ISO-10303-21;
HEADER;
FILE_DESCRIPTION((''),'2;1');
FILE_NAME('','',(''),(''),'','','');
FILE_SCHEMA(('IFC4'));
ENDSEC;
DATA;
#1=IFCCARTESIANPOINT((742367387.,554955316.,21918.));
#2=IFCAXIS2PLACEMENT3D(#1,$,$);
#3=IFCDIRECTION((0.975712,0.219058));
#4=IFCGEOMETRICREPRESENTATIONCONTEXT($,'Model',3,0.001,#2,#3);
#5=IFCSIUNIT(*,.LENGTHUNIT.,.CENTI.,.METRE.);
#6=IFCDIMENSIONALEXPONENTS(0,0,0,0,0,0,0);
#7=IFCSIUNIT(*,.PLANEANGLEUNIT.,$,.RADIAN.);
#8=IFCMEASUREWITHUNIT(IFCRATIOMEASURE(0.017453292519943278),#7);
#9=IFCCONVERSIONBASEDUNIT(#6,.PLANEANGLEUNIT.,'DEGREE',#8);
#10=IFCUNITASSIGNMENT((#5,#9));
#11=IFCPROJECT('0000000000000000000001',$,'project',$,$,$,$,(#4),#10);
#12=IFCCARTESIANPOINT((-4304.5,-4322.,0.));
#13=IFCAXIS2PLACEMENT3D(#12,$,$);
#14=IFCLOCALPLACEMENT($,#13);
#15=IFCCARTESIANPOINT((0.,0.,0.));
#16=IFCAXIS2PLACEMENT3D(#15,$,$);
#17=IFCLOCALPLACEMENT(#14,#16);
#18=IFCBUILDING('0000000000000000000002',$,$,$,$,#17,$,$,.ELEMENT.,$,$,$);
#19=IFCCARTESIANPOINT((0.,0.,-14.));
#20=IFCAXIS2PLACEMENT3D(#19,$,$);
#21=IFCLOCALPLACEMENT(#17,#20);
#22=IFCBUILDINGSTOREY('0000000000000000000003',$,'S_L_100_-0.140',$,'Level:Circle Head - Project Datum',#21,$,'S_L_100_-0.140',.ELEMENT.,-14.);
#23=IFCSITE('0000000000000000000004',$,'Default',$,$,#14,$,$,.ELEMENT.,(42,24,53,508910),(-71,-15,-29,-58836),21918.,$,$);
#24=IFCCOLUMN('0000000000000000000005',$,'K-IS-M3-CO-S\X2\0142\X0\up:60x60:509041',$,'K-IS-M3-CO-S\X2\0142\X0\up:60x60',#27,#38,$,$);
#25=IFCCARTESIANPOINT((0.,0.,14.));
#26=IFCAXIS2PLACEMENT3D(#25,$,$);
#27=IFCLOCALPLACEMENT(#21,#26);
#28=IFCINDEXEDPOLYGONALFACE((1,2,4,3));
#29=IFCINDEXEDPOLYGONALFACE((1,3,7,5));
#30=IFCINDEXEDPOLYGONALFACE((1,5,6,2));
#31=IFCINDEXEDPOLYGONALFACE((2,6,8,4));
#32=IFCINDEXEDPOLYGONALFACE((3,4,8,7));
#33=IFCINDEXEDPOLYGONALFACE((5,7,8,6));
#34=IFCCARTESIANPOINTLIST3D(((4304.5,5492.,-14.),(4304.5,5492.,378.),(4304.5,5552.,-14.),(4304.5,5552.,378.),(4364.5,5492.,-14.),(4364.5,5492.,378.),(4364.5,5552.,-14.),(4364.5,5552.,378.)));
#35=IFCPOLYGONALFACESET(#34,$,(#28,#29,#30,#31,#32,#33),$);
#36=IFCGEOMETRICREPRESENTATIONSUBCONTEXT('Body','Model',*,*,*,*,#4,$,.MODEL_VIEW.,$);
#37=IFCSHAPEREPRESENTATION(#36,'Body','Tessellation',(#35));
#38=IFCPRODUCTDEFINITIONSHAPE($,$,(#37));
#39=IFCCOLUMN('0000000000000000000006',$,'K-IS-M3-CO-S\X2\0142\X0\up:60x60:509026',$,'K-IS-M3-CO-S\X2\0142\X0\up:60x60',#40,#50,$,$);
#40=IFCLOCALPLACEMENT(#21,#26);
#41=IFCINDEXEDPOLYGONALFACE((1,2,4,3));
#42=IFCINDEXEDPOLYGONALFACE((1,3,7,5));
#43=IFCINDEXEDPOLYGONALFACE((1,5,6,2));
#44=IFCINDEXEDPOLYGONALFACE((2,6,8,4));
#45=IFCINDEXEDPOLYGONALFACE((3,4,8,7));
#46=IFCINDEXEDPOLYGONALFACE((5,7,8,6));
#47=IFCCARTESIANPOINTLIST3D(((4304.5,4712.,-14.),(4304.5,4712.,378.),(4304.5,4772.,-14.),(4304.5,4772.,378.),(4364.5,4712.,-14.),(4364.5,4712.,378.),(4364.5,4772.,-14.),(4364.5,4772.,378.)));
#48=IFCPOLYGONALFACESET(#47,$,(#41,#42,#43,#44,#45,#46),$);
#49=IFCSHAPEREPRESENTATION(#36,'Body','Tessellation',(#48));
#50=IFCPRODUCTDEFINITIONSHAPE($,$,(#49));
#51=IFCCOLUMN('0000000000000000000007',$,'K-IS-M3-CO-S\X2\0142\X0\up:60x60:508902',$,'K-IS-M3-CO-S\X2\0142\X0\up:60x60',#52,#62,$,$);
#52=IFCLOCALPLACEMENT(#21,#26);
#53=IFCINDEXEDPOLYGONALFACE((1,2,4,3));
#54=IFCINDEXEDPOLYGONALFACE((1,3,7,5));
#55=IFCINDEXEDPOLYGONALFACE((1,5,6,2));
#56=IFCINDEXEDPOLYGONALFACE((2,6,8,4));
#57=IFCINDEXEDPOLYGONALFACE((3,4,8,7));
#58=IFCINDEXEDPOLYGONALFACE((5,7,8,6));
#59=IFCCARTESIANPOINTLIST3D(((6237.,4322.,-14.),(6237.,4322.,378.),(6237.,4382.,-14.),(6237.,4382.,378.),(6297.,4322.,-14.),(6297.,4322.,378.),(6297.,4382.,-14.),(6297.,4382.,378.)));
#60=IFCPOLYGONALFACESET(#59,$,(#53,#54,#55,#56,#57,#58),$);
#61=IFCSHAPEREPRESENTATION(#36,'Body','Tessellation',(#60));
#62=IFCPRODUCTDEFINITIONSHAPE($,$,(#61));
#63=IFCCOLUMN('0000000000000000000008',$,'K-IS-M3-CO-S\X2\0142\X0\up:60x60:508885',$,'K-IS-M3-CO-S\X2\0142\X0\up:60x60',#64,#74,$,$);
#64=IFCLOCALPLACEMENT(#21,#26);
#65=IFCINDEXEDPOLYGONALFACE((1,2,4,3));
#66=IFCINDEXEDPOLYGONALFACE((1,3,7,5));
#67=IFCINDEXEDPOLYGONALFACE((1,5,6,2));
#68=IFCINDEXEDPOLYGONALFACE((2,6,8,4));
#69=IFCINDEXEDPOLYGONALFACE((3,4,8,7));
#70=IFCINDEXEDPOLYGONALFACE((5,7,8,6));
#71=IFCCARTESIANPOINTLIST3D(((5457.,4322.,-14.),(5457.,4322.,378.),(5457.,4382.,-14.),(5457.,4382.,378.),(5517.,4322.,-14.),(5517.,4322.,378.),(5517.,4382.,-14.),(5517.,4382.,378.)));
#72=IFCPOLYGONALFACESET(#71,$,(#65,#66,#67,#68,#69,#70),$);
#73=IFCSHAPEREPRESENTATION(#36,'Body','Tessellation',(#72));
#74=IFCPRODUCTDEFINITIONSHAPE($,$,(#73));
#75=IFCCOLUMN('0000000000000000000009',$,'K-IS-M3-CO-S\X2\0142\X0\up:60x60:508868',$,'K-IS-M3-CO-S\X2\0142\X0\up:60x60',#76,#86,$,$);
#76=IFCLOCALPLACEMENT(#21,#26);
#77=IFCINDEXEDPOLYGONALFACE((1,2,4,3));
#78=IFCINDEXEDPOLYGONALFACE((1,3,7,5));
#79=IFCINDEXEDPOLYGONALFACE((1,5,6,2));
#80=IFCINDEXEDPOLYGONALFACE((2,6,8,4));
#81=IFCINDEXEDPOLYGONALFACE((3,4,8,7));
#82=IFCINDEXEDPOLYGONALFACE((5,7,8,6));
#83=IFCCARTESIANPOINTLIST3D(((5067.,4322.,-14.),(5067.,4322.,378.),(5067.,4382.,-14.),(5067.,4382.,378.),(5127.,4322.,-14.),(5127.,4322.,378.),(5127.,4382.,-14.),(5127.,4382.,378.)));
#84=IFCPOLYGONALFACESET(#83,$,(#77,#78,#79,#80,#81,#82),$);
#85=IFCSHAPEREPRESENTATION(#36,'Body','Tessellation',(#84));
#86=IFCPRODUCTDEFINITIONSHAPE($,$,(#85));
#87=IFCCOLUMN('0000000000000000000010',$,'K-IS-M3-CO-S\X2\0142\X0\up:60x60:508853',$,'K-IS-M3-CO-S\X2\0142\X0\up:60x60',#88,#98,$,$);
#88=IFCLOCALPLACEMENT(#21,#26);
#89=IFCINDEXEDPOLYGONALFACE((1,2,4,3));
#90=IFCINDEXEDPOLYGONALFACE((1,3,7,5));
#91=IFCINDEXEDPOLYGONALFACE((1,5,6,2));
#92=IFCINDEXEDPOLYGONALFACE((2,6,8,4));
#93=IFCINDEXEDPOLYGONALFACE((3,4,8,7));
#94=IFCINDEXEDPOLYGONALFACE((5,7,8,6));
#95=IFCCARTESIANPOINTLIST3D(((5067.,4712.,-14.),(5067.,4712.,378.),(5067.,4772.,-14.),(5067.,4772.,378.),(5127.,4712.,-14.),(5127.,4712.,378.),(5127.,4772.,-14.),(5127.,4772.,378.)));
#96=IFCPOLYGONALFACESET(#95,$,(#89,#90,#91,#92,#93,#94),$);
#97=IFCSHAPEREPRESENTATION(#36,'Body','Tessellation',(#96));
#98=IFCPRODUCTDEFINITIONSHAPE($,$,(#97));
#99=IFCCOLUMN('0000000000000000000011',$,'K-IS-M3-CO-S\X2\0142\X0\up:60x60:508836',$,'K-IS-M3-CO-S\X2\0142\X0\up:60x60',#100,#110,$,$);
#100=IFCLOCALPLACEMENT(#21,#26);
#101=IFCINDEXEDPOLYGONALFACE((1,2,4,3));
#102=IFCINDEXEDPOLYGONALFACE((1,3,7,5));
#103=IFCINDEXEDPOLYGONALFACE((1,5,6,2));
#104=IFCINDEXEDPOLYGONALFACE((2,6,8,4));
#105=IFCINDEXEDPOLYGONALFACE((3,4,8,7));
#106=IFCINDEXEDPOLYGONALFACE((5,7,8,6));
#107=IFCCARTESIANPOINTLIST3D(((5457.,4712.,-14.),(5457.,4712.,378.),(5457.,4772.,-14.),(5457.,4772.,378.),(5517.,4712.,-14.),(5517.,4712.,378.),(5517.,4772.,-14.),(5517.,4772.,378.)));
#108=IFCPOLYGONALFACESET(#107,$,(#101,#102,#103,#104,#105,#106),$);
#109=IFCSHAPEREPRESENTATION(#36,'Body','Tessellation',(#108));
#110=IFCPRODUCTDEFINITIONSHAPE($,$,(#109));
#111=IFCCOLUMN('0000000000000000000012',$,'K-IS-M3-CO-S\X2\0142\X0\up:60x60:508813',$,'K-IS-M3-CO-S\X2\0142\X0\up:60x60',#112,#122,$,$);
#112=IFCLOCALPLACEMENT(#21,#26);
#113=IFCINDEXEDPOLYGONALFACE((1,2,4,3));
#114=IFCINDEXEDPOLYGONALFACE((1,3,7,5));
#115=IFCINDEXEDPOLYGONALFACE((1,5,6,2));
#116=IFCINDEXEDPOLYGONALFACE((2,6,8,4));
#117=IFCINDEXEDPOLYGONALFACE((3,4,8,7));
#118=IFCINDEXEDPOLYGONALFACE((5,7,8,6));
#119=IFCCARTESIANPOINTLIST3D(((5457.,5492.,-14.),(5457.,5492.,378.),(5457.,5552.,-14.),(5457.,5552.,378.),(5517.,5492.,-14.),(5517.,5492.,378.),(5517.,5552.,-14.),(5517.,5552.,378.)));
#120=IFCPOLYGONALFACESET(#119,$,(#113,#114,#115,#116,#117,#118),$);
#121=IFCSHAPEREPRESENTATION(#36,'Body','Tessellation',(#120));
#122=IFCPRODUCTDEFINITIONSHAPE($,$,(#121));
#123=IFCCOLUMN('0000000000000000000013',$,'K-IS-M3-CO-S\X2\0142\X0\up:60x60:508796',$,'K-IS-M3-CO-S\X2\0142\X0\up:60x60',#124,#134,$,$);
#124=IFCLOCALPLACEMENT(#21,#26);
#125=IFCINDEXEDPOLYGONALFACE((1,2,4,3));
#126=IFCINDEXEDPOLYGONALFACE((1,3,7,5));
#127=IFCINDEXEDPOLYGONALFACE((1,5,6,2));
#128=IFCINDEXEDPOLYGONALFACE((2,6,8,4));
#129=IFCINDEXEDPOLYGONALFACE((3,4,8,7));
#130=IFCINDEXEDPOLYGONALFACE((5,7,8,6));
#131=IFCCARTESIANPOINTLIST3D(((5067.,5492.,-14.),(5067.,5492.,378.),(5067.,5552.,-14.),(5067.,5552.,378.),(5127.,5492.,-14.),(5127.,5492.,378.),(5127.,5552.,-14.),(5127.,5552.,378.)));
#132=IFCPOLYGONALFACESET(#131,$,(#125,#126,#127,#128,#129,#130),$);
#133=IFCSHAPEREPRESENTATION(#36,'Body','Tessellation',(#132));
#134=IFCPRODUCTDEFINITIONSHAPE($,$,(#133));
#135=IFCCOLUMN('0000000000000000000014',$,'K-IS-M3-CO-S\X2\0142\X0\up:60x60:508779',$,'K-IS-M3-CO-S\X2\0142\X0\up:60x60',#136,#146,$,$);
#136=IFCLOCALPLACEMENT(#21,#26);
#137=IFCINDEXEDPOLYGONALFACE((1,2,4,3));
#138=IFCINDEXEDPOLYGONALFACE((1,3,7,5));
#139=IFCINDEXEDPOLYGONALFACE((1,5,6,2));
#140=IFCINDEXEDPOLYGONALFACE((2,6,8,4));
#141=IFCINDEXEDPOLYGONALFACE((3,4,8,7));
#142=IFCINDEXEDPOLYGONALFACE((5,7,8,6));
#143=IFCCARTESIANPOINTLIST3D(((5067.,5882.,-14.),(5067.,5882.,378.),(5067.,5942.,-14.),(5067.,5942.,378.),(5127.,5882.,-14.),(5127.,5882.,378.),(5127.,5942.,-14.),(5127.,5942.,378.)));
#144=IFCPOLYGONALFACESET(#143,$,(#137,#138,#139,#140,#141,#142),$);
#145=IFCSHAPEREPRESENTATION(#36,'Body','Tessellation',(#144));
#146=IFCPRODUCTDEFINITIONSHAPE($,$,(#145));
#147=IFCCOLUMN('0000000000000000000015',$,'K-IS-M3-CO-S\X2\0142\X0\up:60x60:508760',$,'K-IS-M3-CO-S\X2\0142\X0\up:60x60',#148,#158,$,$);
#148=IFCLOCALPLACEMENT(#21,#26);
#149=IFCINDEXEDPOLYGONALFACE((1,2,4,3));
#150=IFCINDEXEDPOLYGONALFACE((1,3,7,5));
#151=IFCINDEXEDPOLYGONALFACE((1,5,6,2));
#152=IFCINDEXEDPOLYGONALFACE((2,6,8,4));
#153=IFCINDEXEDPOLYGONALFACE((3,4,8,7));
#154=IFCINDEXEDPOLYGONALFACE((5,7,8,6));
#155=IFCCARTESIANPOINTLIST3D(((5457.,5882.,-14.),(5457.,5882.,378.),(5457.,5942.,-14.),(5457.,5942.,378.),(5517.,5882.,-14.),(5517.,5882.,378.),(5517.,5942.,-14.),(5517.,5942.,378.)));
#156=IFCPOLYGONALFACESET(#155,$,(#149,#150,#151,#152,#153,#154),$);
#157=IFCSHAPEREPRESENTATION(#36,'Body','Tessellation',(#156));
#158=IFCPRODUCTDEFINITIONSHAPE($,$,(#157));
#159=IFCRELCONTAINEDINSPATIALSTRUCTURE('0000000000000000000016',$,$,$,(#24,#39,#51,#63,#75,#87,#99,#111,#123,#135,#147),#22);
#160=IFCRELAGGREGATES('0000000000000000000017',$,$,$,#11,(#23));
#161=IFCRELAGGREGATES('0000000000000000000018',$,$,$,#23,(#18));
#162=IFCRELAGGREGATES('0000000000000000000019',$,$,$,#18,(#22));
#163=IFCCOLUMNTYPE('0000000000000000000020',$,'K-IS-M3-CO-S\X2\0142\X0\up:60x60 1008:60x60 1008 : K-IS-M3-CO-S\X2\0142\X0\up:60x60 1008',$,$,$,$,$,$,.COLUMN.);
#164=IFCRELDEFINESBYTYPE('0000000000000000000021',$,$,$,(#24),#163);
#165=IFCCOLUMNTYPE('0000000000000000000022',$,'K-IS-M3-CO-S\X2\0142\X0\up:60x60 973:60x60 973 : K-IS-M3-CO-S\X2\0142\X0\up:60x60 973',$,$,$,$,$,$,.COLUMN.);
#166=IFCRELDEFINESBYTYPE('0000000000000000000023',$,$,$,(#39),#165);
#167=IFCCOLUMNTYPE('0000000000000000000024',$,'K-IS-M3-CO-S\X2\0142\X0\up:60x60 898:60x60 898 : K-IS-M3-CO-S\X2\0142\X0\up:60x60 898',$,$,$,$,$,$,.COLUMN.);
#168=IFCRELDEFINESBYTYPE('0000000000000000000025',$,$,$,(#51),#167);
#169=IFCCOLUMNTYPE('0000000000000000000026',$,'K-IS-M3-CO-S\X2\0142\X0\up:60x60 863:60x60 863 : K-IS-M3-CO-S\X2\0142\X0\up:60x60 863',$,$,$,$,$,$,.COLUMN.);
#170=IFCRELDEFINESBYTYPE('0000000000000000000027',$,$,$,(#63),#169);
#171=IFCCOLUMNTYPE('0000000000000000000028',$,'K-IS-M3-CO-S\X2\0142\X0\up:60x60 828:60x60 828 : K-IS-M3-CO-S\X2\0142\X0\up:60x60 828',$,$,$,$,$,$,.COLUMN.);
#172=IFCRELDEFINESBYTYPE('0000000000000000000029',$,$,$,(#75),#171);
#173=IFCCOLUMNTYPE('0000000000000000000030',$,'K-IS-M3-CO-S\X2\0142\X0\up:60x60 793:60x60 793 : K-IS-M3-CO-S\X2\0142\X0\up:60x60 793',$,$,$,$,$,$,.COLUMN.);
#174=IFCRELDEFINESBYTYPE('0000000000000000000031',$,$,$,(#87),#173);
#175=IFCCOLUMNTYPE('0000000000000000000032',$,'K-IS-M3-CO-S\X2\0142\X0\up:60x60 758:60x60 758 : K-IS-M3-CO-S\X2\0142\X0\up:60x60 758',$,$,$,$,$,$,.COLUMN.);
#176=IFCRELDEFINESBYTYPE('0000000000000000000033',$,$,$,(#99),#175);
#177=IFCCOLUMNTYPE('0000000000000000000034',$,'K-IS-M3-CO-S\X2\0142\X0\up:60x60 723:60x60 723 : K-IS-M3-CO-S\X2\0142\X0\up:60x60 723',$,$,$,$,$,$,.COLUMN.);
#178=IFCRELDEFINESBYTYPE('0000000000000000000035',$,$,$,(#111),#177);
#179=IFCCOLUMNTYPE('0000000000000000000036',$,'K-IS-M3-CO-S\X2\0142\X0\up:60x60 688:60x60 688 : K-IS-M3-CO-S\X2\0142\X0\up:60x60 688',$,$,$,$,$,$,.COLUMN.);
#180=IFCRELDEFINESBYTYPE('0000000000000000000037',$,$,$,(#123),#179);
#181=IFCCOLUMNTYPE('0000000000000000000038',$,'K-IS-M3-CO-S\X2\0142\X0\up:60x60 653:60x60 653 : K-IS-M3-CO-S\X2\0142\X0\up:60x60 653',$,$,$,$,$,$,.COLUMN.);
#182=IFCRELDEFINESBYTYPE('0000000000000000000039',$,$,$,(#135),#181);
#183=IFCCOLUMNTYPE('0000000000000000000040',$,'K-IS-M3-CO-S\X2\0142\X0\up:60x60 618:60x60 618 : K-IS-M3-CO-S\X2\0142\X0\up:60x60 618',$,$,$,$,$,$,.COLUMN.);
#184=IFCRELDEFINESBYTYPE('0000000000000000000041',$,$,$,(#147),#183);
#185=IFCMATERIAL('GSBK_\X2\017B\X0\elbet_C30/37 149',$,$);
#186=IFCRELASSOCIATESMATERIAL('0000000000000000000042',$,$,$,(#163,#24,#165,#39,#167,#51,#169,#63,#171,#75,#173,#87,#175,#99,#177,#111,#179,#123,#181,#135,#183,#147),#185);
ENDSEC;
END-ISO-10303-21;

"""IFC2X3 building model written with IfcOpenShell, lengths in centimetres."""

from ifc_helpers import new_model, entity, si_unit, converted_unit, direction, frame, frame_2d, origin, origin_2d_with_axis, place, context, subcontext, project, spatial, rectangle, extrude, source, transform, mapped, material, type_object, type_shapes, element, save


model = new_model("IFC2X3")

# Units and contexts
model_context = context("Model", 3, precision=0.001, world=frame((742367387.0, 554955316.0, 21918.0)), true_north=direction((0.975712, 0.219058)))
body_context = subcontext(model_context, "Body", "Model", "MODEL_VIEW")
ifc_project = project(units=[si_unit("LENGTHUNIT", "METRE", prefix="CENTI"), converted_unit("PLANEANGLEUNIT", "DEGREE", entity("IfcRatioMeasure", 0.017453292519943278), si_unit("PLANEANGLEUNIT", "RADIAN"), dimensions=[0, 0, 0, 0, 0, 0, 0])], contexts=[model_context])

# Site, building, storey
site_placement = place(None, frame((-4304.5, -4322.0, 0.0)))
site = spatial("IfcSite", under=ifc_project, at=site_placement, Name="Default", CompositionType="ELEMENT", RefLatitude=(42, 24, 53, 508910), RefLongitude=(-71, -15, -29, -58836), RefElevation=21918.0)
building_placement = place(site_placement, origin())
building = spatial("IfcBuilding", under=site, at=building_placement, CompositionType="ELEMENT")
storey_placement = place(building_placement, frame((0.0, 0.0, -14.0)))
storey = spatial("IfcBuildingStorey", under=building, at=storey_placement, Name="S_L_100_-0.140", ObjectType="Level:Circle Head - Project Datum", LongName="S_L_100_-0.140", CompositionType="ELEMENT", Elevation=-14.0)

# Columns
ifc_material = material(Name="GSBK_Żelbet_C30/37 149")
column_type_1 = type_object("IfcColumnType", Name="K-IS-M3-CO-Słup:60x60 1008:60x60 1008 : K-IS-M3-CO-Słup:60x60 1008", PredefinedType="COLUMN", material=ifc_material)
shared_shape_1 = source(origin(), body_context, "Body", "SweptSolid", [
    extrude(rectangle(XDim=60.0, YDim=60.0, at=origin_2d_with_axis()), frame((4334.5, 5522.0, -14.0), z_axis=(0.0, 0.0, 1.0), x_axis=(0.0, -1.0, 0.0)), (0.0, 0.0, 1.0), 392.0),
])
type_shapes(column_type_1, [shared_shape_1])
column_1_placement = place(storey_placement, frame((0.0, 0.0, 14.0)))
element("IfcColumn", 1, at=column_1_placement, inside=storey, type_object=column_type_1, material=ifc_material, Name="K-IS-M3-CO-Słup:60x60:509041", ObjectType="K-IS-M3-CO-Słup:60x60", context=body_context, shape_type="MappedRepresentation", body=[
    mapped(shared_shape_1, transform((0.0, 0.0, 0.0), scale=1.0)),
])
column_type_2 = type_object("IfcColumnType", Name="K-IS-M3-CO-Słup:60x60 973:60x60 973 : K-IS-M3-CO-Słup:60x60 973", PredefinedType="COLUMN", material=ifc_material)
shared_shape_2 = source(origin(), body_context, "Body", "SweptSolid", [
    extrude(rectangle(XDim=60.0, YDim=60.0, at=frame_2d((0.0, 0.0), x_axis=(1.0, 0.0))), frame((4334.5, 4742.0, -14.0), z_axis=(0.0, 0.0, 1.0), x_axis=(0.0, -1.0, 0.0)), (0.0, 0.0, 1.0), 392.0),
])
type_shapes(column_type_2, [shared_shape_2])
column_2_placement = place(storey_placement, frame((0.0, 0.0, 14.0)))
element("IfcColumn", 2, at=column_2_placement, inside=storey, type_object=column_type_2, material=ifc_material, Name="K-IS-M3-CO-Słup:60x60:509026", ObjectType="K-IS-M3-CO-Słup:60x60", context=body_context, shape_type="MappedRepresentation", body=[
    mapped(shared_shape_2, transform((0.0, 0.0, 0.0), scale=1.0)),
])
column_type_3 = type_object("IfcColumnType", Name="K-IS-M3-CO-Słup:60x60 898:60x60 898 : K-IS-M3-CO-Słup:60x60 898", PredefinedType="COLUMN", material=ifc_material)
shared_shape_3 = source(origin(), body_context, "Body", "SweptSolid", [
    extrude(rectangle(XDim=60.0, YDim=60.0, at=origin_2d_with_axis()), frame((6267.0, 4352.0, -14.0), z_axis=(0.0, 0.0, 1.0), x_axis=(0.0, -1.0, 0.0)), (0.0, 0.0, 1.0), 392.0),
])
type_shapes(column_type_3, [shared_shape_3])
column_3_placement = place(storey_placement, frame((0.0, 0.0, 14.0)))
element("IfcColumn", 3, at=column_3_placement, inside=storey, type_object=column_type_3, material=ifc_material, Name="K-IS-M3-CO-Słup:60x60:508902", ObjectType="K-IS-M3-CO-Słup:60x60", context=body_context, shape_type="MappedRepresentation", body=[
    mapped(shared_shape_3, transform((0.0, 0.0, 0.0), scale=1.0)),
])
column_type_4 = type_object("IfcColumnType", Name="K-IS-M3-CO-Słup:60x60 863:60x60 863 : K-IS-M3-CO-Słup:60x60 863", PredefinedType="COLUMN", material=ifc_material)
shared_shape_4 = source(origin(), body_context, "Body", "SweptSolid", [
    extrude(rectangle(XDim=60.0, YDim=60.0, at=origin_2d_with_axis()), frame((5487.0, 4352.0, -14.0), z_axis=(0.0, 0.0, 1.0), x_axis=(0.0, -1.0, 0.0)), (0.0, 0.0, 1.0), 392.0),
])
type_shapes(column_type_4, [shared_shape_4])
column_4_placement = place(storey_placement, frame((0.0, 0.0, 14.0)))
element("IfcColumn", 4, at=column_4_placement, inside=storey, type_object=column_type_4, material=ifc_material, Name="K-IS-M3-CO-Słup:60x60:508885", ObjectType="K-IS-M3-CO-Słup:60x60", context=body_context, shape_type="MappedRepresentation", body=[
    mapped(shared_shape_4, transform((0.0, 0.0, 0.0), scale=1.0)),
])
column_type_5 = type_object("IfcColumnType", Name="K-IS-M3-CO-Słup:60x60 828:60x60 828 : K-IS-M3-CO-Słup:60x60 828", PredefinedType="COLUMN", material=ifc_material)
shared_shape_5 = source(origin(), body_context, "Body", "SweptSolid", [
    extrude(rectangle(XDim=60.0, YDim=60.0, at=origin_2d_with_axis()), frame((5097.0, 4352.0, -14.0), z_axis=(0.0, 0.0, 1.0), x_axis=(0.0, -1.0, 0.0)), (0.0, 0.0, 1.0), 392.0),
])
type_shapes(column_type_5, [shared_shape_5])
column_5_placement = place(storey_placement, frame((0.0, 0.0, 14.0)))
element("IfcColumn", 5, at=column_5_placement, inside=storey, type_object=column_type_5, material=ifc_material, Name="K-IS-M3-CO-Słup:60x60:508868", ObjectType="K-IS-M3-CO-Słup:60x60", context=body_context, shape_type="MappedRepresentation", body=[
    mapped(shared_shape_5, transform((0.0, 0.0, 0.0), scale=1.0)),
])
column_type_6 = type_object("IfcColumnType", Name="K-IS-M3-CO-Słup:60x60 793:60x60 793 : K-IS-M3-CO-Słup:60x60 793", PredefinedType="COLUMN", material=ifc_material)
shared_shape_6 = source(origin(), body_context, "Body", "SweptSolid", [
    extrude(rectangle(XDim=60.0, YDim=60.0, at=frame_2d((0.0, 0.0), x_axis=(1.0, 0.0))), frame((5097.0, 4742.0, -14.0), z_axis=(0.0, 0.0, 1.0), x_axis=(0.0, -1.0, 0.0)), (0.0, 0.0, 1.0), 392.0),
])
type_shapes(column_type_6, [shared_shape_6])
column_6_placement = place(storey_placement, frame((0.0, 0.0, 14.0)))
element("IfcColumn", 6, at=column_6_placement, inside=storey, type_object=column_type_6, material=ifc_material, Name="K-IS-M3-CO-Słup:60x60:508853", ObjectType="K-IS-M3-CO-Słup:60x60", context=body_context, shape_type="MappedRepresentation", body=[
    mapped(shared_shape_6, transform((0.0, 0.0, 0.0), scale=1.0)),
])
column_type_7 = type_object("IfcColumnType", Name="K-IS-M3-CO-Słup:60x60 758:60x60 758 : K-IS-M3-CO-Słup:60x60 758", PredefinedType="COLUMN", material=ifc_material)
shared_shape_7 = source(origin(), body_context, "Body", "SweptSolid", [
    extrude(rectangle(XDim=60.0, YDim=60.0, at=frame_2d((0.0, 0.0), x_axis=(1.0, 0.0))), frame((5487.0, 4742.0, -14.0), z_axis=(0.0, 0.0, 1.0), x_axis=(0.0, -1.0, 0.0)), (0.0, 0.0, 1.0), 392.0),
])
type_shapes(column_type_7, [shared_shape_7])
column_7_placement = place(storey_placement, frame((0.0, 0.0, 14.0)))
element("IfcColumn", 7, at=column_7_placement, inside=storey, type_object=column_type_7, material=ifc_material, Name="K-IS-M3-CO-Słup:60x60:508836", ObjectType="K-IS-M3-CO-Słup:60x60", context=body_context, shape_type="MappedRepresentation", body=[
    mapped(shared_shape_7, transform((0.0, 0.0, 0.0), scale=1.0)),
])
column_type_8 = type_object("IfcColumnType", Name="K-IS-M3-CO-Słup:60x60 723:60x60 723 : K-IS-M3-CO-Słup:60x60 723", PredefinedType="COLUMN", material=ifc_material)
shared_shape_8 = source(origin(), body_context, "Body", "SweptSolid", [
    extrude(rectangle(XDim=60.0, YDim=60.0, at=origin_2d_with_axis()), frame((5487.0, 5522.0, -14.0), z_axis=(0.0, 0.0, 1.0), x_axis=(0.0, -1.0, 0.0)), (0.0, 0.0, 1.0), 392.0),
])
type_shapes(column_type_8, [shared_shape_8])
column_8_placement = place(storey_placement, frame((0.0, 0.0, 14.0)))
element("IfcColumn", 8, at=column_8_placement, inside=storey, type_object=column_type_8, material=ifc_material, Name="K-IS-M3-CO-Słup:60x60:508813", ObjectType="K-IS-M3-CO-Słup:60x60", context=body_context, shape_type="MappedRepresentation", body=[
    mapped(shared_shape_8, transform((0.0, 0.0, 0.0), scale=1.0)),
])
column_type_9 = type_object("IfcColumnType", Name="K-IS-M3-CO-Słup:60x60 688:60x60 688 : K-IS-M3-CO-Słup:60x60 688", PredefinedType="COLUMN", material=ifc_material)
shared_shape_9 = source(origin(), body_context, "Body", "SweptSolid", [
    extrude(rectangle(XDim=60.0, YDim=60.0, at=origin_2d_with_axis()), frame((5097.0, 5522.0, -14.0), z_axis=(0.0, 0.0, 1.0), x_axis=(0.0, -1.0, 0.0)), (0.0, 0.0, 1.0), 392.0),
])
type_shapes(column_type_9, [shared_shape_9])
column_9_placement = place(storey_placement, frame((0.0, 0.0, 14.0)))
element("IfcColumn", 9, at=column_9_placement, inside=storey, type_object=column_type_9, material=ifc_material, Name="K-IS-M3-CO-Słup:60x60:508796", ObjectType="K-IS-M3-CO-Słup:60x60", context=body_context, shape_type="MappedRepresentation", body=[
    mapped(shared_shape_9, transform((0.0, 0.0, 0.0), scale=1.0)),
])
column_type_10 = type_object("IfcColumnType", Name="K-IS-M3-CO-Słup:60x60 653:60x60 653 : K-IS-M3-CO-Słup:60x60 653", PredefinedType="COLUMN", material=ifc_material)
shared_shape_10 = source(origin(), body_context, "Body", "SweptSolid", [
    extrude(rectangle(XDim=60.0, YDim=60.0, at=frame_2d((0.0, 0.0), x_axis=(1.0, 0.0))), frame((5097.0, 5912.0, -14.0), z_axis=(0.0, 0.0, 1.0), x_axis=(0.0, -1.0, 0.0)), (0.0, 0.0, 1.0), 392.0),
])
type_shapes(column_type_10, [shared_shape_10])
column_10_placement = place(storey_placement, frame((0.0, 0.0, 14.0)))
element("IfcColumn", 10, at=column_10_placement, inside=storey, type_object=column_type_10, material=ifc_material, Name="K-IS-M3-CO-Słup:60x60:508779", ObjectType="K-IS-M3-CO-Słup:60x60", context=body_context, shape_type="MappedRepresentation", body=[
    mapped(shared_shape_10, transform((0.0, 0.0, 0.0), scale=1.0)),
])
column_type_11 = type_object("IfcColumnType", Name="K-IS-M3-CO-Słup:60x60 618:60x60 618 : K-IS-M3-CO-Słup:60x60 618", PredefinedType="COLUMN", material=ifc_material)
shared_shape_11 = source(origin(), body_context, "Body", "SweptSolid", [
    extrude(rectangle(XDim=60.0, YDim=60.0, at=frame_2d((0.0, 0.0), x_axis=(1.0, 0.0))), frame((5487.0, 5912.0, -14.0), z_axis=(0.0, 0.0, 1.0), x_axis=(0.0, -1.0, 0.0)), (0.0, 0.0, 1.0), 392.0),
])
type_shapes(column_type_11, [shared_shape_11])
column_11_placement = place(storey_placement, frame((0.0, 0.0, 14.0)))
element("IfcColumn", 11, at=column_11_placement, inside=storey, type_object=column_type_11, material=ifc_material, Name="K-IS-M3-CO-Słup:60x60:508760", ObjectType="K-IS-M3-CO-Słup:60x60", context=body_context, shape_type="MappedRepresentation", body=[
    mapped(shared_shape_11, transform((0.0, 0.0, 0.0), scale=1.0)),
])

save(model, "model.ifc")
